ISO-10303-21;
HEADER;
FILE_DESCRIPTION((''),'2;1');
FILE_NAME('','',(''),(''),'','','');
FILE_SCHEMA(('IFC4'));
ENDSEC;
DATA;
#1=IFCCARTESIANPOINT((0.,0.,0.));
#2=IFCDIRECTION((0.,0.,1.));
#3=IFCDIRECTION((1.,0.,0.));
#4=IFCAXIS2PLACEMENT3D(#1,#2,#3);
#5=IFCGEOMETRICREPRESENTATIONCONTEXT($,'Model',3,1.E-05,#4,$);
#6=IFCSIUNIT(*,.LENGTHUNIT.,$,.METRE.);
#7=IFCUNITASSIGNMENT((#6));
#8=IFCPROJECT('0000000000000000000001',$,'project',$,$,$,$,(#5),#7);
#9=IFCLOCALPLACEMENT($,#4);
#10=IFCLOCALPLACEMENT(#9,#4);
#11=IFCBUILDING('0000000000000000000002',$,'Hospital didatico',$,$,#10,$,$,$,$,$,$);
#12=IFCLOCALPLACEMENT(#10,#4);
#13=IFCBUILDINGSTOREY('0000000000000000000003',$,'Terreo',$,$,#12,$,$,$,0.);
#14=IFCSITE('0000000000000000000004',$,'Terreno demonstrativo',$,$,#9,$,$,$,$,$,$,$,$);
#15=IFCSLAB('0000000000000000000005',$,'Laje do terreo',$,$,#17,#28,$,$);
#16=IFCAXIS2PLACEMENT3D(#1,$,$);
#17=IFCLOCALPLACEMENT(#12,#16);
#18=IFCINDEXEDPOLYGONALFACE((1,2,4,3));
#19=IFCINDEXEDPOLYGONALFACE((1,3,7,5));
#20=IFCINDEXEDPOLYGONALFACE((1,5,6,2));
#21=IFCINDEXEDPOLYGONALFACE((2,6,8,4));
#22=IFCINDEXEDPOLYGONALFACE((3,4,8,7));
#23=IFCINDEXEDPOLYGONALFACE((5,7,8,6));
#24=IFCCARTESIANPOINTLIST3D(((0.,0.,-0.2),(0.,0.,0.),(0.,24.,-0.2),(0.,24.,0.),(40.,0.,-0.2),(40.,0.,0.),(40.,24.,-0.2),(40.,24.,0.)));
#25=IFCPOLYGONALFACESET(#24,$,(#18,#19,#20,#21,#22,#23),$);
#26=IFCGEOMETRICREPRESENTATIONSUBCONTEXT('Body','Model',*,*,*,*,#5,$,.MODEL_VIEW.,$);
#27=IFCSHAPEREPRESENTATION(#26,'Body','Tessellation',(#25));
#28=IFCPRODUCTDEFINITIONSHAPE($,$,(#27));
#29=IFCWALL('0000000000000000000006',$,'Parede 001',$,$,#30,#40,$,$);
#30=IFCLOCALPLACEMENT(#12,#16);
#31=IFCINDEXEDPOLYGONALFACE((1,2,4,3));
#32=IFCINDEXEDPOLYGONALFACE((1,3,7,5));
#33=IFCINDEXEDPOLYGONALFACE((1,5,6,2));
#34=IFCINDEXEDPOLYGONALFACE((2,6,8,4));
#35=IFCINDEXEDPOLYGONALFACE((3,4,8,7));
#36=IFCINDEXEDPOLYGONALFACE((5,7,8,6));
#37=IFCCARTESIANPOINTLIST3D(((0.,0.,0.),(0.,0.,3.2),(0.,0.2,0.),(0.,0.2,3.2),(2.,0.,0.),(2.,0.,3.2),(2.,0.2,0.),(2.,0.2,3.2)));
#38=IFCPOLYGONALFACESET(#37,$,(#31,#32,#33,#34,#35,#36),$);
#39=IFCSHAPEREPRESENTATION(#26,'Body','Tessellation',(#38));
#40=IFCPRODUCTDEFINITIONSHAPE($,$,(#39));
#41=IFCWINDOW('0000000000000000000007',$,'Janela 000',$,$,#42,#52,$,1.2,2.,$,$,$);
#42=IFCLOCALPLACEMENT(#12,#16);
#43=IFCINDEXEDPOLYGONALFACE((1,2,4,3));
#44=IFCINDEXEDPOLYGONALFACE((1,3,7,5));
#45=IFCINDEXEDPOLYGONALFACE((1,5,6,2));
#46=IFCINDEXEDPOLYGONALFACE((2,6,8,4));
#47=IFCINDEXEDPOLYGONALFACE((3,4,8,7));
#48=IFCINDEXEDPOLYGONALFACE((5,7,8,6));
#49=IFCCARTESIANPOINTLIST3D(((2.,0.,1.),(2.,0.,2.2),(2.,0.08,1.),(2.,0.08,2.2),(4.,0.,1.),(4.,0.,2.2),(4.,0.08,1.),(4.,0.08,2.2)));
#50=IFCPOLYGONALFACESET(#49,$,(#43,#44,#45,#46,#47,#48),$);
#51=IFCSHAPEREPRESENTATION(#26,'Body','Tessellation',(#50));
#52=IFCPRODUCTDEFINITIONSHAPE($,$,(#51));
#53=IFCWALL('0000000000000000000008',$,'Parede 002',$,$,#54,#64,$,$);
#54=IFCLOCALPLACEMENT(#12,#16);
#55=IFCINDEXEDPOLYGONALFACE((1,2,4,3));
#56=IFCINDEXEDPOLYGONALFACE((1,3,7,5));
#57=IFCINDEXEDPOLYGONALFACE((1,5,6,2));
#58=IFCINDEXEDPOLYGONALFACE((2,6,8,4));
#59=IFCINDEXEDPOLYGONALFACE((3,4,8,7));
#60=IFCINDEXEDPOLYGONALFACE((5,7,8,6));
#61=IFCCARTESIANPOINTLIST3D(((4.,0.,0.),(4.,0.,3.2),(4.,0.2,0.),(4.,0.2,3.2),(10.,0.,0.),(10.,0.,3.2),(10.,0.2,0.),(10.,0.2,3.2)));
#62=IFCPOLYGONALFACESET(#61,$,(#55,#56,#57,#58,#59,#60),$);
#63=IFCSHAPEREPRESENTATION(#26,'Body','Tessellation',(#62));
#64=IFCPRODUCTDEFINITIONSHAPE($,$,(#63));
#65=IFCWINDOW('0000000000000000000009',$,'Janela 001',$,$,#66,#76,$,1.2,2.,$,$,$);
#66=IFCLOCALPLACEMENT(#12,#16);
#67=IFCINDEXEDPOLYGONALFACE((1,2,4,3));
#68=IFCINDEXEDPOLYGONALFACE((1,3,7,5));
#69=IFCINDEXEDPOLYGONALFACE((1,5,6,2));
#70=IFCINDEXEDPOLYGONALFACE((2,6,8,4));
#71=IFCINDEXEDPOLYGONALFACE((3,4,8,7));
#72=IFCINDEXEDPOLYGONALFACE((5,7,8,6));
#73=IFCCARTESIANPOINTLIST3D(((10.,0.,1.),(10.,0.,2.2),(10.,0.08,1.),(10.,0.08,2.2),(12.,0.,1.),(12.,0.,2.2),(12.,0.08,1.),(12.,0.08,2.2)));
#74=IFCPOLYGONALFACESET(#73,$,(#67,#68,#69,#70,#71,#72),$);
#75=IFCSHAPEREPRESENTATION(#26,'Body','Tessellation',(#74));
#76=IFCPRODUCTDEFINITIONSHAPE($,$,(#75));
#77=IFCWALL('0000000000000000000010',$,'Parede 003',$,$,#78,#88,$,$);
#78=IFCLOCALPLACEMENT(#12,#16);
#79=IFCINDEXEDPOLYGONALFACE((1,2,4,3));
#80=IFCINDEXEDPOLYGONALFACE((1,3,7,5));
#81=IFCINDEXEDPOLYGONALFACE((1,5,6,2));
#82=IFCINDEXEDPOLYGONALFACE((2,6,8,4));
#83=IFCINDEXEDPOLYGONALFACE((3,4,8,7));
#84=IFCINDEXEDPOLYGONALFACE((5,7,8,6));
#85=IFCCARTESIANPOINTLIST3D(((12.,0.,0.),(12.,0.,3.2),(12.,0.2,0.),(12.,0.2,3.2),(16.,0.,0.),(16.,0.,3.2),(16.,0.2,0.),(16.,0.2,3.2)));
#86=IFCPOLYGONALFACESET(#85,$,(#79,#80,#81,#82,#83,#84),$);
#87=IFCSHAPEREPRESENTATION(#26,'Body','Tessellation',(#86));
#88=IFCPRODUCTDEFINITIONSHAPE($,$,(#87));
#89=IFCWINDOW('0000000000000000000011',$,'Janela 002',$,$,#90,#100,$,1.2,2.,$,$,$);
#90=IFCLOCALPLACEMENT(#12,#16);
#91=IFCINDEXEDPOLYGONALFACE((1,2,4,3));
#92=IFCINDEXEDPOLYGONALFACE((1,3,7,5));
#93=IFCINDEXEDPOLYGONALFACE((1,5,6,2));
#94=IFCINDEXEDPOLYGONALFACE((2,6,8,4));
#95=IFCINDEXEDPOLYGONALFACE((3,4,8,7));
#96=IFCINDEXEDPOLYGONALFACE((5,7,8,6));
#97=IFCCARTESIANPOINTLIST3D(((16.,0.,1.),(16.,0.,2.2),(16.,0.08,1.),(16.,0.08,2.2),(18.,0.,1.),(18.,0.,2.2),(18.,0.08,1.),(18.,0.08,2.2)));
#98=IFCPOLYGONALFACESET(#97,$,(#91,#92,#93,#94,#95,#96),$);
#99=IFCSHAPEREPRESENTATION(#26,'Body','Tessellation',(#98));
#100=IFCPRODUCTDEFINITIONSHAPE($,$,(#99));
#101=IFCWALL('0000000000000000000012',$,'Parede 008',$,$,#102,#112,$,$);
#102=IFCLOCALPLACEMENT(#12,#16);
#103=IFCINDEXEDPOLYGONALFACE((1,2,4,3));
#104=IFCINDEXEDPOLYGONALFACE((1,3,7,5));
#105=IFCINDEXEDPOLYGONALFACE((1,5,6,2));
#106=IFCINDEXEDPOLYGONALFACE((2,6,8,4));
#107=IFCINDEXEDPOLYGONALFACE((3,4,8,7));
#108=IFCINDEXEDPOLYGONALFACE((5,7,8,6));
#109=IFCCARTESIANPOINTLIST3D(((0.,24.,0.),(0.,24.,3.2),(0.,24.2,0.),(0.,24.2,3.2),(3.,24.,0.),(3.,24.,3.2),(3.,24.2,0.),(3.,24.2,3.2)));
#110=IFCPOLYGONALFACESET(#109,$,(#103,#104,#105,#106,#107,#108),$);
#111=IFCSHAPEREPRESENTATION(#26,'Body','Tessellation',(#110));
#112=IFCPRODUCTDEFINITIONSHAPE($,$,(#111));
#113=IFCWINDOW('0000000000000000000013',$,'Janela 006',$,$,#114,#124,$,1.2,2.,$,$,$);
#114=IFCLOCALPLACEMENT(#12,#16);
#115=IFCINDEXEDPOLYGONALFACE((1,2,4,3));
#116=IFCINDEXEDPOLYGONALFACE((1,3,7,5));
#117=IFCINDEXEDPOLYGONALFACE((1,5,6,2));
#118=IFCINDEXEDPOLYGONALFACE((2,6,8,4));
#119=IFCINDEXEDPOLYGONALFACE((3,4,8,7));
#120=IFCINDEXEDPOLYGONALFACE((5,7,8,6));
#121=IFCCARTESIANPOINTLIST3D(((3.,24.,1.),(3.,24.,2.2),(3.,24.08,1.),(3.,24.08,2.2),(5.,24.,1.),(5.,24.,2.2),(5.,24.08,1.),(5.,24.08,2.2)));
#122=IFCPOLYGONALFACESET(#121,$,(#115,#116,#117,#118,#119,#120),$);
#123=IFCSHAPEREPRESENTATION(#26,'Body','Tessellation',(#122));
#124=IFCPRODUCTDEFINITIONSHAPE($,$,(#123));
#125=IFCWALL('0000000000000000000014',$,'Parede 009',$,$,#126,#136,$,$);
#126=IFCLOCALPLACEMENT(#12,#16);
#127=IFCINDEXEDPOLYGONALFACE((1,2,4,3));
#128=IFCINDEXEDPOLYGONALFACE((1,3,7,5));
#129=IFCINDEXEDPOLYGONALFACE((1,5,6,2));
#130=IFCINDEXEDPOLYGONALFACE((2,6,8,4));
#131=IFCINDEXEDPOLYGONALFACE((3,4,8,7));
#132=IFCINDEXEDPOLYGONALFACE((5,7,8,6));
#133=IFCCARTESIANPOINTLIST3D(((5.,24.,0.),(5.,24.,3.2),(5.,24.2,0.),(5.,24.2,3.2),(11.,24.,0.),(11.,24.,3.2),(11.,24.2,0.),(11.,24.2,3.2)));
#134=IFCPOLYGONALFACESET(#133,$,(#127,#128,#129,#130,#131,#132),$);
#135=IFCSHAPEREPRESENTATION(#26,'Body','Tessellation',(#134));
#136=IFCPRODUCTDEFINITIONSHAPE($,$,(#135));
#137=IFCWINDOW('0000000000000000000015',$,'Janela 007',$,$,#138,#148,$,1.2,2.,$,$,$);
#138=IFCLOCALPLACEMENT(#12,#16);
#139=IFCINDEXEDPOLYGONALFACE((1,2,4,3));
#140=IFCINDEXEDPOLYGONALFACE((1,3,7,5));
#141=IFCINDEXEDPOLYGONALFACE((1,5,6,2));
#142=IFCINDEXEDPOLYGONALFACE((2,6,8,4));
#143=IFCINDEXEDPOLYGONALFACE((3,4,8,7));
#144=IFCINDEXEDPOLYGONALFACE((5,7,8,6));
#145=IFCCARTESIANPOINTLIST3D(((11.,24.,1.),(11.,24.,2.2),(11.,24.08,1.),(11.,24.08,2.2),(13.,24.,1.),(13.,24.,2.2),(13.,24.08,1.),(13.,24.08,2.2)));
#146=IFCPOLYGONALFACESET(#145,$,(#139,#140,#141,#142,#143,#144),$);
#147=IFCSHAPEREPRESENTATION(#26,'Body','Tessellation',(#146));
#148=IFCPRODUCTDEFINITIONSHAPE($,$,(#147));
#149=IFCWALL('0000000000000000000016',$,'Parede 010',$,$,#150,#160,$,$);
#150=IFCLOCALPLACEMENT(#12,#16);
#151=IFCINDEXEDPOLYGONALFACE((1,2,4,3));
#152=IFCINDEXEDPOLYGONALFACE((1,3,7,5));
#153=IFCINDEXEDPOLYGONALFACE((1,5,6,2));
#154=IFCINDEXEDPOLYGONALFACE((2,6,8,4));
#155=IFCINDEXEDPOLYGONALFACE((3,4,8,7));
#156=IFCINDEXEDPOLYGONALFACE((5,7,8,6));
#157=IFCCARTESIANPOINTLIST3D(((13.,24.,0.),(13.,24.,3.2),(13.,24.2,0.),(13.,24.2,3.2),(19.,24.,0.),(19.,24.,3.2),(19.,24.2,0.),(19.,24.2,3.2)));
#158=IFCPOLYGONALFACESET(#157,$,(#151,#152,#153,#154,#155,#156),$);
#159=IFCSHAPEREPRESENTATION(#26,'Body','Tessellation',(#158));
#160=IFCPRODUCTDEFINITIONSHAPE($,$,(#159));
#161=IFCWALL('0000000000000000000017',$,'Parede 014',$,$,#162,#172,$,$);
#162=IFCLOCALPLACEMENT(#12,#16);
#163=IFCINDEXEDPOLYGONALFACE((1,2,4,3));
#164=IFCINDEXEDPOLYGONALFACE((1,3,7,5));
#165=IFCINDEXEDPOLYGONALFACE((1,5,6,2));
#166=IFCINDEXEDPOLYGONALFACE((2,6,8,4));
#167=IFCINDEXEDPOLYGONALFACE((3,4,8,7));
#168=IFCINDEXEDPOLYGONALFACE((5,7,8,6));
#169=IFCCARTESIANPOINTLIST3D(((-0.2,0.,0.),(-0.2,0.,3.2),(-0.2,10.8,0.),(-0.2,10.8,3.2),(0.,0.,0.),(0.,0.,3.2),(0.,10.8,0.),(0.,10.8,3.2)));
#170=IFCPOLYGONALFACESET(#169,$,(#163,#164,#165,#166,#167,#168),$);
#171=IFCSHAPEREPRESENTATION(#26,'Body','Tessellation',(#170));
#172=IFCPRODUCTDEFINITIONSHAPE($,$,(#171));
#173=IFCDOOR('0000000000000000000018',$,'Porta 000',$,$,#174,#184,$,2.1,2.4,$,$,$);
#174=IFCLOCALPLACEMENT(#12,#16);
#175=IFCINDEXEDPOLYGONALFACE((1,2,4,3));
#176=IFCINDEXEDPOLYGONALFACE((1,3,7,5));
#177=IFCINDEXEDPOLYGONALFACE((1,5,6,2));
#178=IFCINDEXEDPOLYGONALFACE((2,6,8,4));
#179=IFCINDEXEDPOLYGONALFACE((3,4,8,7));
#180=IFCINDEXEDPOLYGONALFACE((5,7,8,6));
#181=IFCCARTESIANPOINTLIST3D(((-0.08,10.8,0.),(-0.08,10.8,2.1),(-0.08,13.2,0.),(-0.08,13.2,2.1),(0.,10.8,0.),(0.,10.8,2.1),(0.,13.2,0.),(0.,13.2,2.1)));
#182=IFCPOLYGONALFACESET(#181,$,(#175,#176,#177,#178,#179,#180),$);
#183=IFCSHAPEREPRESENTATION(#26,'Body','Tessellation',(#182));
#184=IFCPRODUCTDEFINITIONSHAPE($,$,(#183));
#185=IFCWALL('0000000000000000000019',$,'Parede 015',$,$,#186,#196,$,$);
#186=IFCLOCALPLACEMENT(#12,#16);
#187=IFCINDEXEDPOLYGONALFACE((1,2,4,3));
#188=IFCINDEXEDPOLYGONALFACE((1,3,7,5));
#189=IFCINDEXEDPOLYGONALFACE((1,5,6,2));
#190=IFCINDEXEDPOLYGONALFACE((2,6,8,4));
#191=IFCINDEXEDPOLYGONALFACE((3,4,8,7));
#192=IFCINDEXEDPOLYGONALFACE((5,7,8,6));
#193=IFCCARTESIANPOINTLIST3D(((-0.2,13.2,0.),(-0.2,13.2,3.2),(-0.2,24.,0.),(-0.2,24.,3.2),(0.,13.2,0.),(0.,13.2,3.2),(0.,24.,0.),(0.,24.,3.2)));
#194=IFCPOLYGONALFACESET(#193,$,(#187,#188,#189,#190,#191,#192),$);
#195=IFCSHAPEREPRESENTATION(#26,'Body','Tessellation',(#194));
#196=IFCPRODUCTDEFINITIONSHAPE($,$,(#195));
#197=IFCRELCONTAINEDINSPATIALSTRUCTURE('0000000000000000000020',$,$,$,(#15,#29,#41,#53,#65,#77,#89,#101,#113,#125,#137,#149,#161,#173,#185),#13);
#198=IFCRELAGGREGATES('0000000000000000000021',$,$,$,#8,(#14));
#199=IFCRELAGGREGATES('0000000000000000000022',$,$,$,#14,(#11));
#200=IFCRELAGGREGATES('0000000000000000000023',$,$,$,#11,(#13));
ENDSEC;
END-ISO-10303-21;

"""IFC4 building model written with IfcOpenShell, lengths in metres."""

from ifc_helpers import new_model, si_unit, frame, origin_with_axes, place, context, subcontext, project, spatial, indexed_curve, outline, extrude, element, save


model = new_model("IFC4")

# Units and contexts
model_context = context("Model", 3, precision=1e-05, world=origin_with_axes())
body_context = subcontext(model_context, "Body", "Model", "MODEL_VIEW")
ifc_project = project(units=[si_unit("LENGTHUNIT", "METRE")], contexts=[model_context])

# Site, building, storey
site_placement = place(None, origin_with_axes())
site = spatial("IfcSite", under=ifc_project, at=site_placement, Name="Terreno demonstrativo")
building_placement = place(site_placement, origin_with_axes())
building = spatial("IfcBuilding", under=site, at=building_placement, Name="Hospital didatico")
storey_placement = place(building_placement, origin_with_axes())
storey = spatial("IfcBuildingStorey", under=building, at=storey_placement, Name="Terreo", Elevation=0.0)

# Slab
slab_placement = place(storey_placement, frame((0.0, 0.0, -0.2), z_axis=(0.0, 0.0, 1.0), x_axis=(1.0, 0.0, 0.0)))
element("IfcSlab", 1, at=slab_placement, inside=storey, Name="Laje do terreo", context=body_context, shape_type="SweptSolid", body=[
    extrude(outline(indexed_curve([(0.0, 0.0), (0.0, 24.0), (40.0, 24.0), (40.0, 0.0), (0.0, 0.0)], self_intersect=False)), origin_with_axes(), (0.0, 0.0, 1.0), 0.2),
])

# Wall
wall_1_placement = place(storey_placement, origin_with_axes())
element("IfcWall", 2, at=wall_1_placement, inside=storey, Name="Parede 001", context=body_context, shape_type="SweptSolid", body=[
    extrude(outline(indexed_curve([(0.0, 0.0), (0.0, 0.2), (2.0, 0.2), (2.0, 0.0), (0.0, 0.0)], self_intersect=False)), origin_with_axes(), (0.0, 0.0, 1.0), 3.2),
])

# Window
window_1_placement = place(storey_placement, frame((2.0, 0.0, 1.0), z_axis=(0.0, 0.0, 1.0), x_axis=(1.0, 0.0, 0.0)))
element("IfcWindow", 3, at=window_1_placement, inside=storey, Name="Janela 000", OverallHeight=1.2, OverallWidth=2.0, context=body_context, shape_type="SweptSolid", body=[
    extrude(outline(indexed_curve([(0.0, 0.0), (0.0, 0.08), (2.0, 0.08), (2.0, 0.0), (0.0, 0.0)], self_intersect=False)), origin_with_axes(), (0.0, 0.0, 1.0), 1.2),
])

# Wall
wall_2_placement = place(storey_placement, frame((4.0, 0.0, 0.0), z_axis=(0.0, 0.0, 1.0), x_axis=(1.0, 0.0, 0.0)))
element("IfcWall", 4, at=wall_2_placement, inside=storey, Name="Parede 002", context=body_context, shape_type="SweptSolid", body=[
    extrude(outline(indexed_curve([(0.0, 0.0), (0.0, 0.2), (6.0, 0.2), (6.0, 0.0), (0.0, 0.0)], self_intersect=False)), origin_with_axes(), (0.0, 0.0, 1.0), 3.2),
])

# Window
window_2_placement = place(storey_placement, frame((10.0, 0.0, 1.0), z_axis=(0.0, 0.0, 1.0), x_axis=(1.0, 0.0, 0.0)))
element("IfcWindow", 5, at=window_2_placement, inside=storey, Name="Janela 001", OverallHeight=1.2, OverallWidth=2.0, context=body_context, shape_type="SweptSolid", body=[
    extrude(outline(indexed_curve([(0.0, 0.0), (0.0, 0.08), (2.0, 0.08), (2.0, 0.0), (0.0, 0.0)], self_intersect=False)), origin_with_axes(), (0.0, 0.0, 1.0), 1.2),
])

# Wall
wall_3_placement = place(storey_placement, frame((12.0, 0.0, 0.0), z_axis=(0.0, 0.0, 1.0), x_axis=(1.0, 0.0, 0.0)))
element("IfcWall", 6, at=wall_3_placement, inside=storey, Name="Parede 003", context=body_context, shape_type="SweptSolid", body=[
    extrude(outline(indexed_curve([(0.0, 0.0), (0.0, 0.2), (4.0, 0.2), (4.0, 0.0), (0.0, 0.0)], self_intersect=False)), origin_with_axes(), (0.0, 0.0, 1.0), 3.2),
])

# Window
window_3_placement = place(storey_placement, frame((16.0, 0.0, 1.0), z_axis=(0.0, 0.0, 1.0), x_axis=(1.0, 0.0, 0.0)))
element("IfcWindow", 7, at=window_3_placement, inside=storey, Name="Janela 002", OverallHeight=1.2, OverallWidth=2.0, context=body_context, shape_type="SweptSolid", body=[
    extrude(outline(indexed_curve([(0.0, 0.0), (0.0, 0.08), (2.0, 0.08), (2.0, 0.0), (0.0, 0.0)], self_intersect=False)), origin_with_axes(), (0.0, 0.0, 1.0), 1.2),
])

# Wall
wall_4_placement = place(storey_placement, frame((0.0, 24.0, 0.0), z_axis=(0.0, 0.0, 1.0), x_axis=(1.0, 0.0, 0.0)))
element("IfcWall", 8, at=wall_4_placement, inside=storey, Name="Parede 008", context=body_context, shape_type="SweptSolid", body=[
    extrude(outline(indexed_curve([(0.0, 0.0), (0.0, 0.2), (3.0, 0.2), (3.0, 0.0), (0.0, 0.0)], self_intersect=False)), origin_with_axes(), (0.0, 0.0, 1.0), 3.2),
])

# Window
window_4_placement = place(storey_placement, frame((3.0, 24.0, 1.0), z_axis=(0.0, 0.0, 1.0), x_axis=(1.0, 0.0, 0.0)))
element("IfcWindow", 9, at=window_4_placement, inside=storey, Name="Janela 006", OverallHeight=1.2, OverallWidth=2.0, context=body_context, shape_type="SweptSolid", body=[
    extrude(outline(indexed_curve([(0.0, 0.0), (0.0, 0.08), (2.0, 0.08), (2.0, 0.0), (0.0, 0.0)], self_intersect=False)), origin_with_axes(), (0.0, 0.0, 1.0), 1.2),
])

# Wall
wall_5_placement = place(storey_placement, frame((5.0, 24.0, 0.0), z_axis=(0.0, 0.0, 1.0), x_axis=(1.0, 0.0, 0.0)))
element("IfcWall", 10, at=wall_5_placement, inside=storey, Name="Parede 009", context=body_context, shape_type="SweptSolid", body=[
    extrude(outline(indexed_curve([(0.0, 0.0), (0.0, 0.2), (6.0, 0.2), (6.0, 0.0), (0.0, 0.0)], self_intersect=False)), origin_with_axes(), (0.0, 0.0, 1.0), 3.2),
])

# Window
window_5_placement = place(storey_placement, frame((11.0, 24.0, 1.0), z_axis=(0.0, 0.0, 1.0), x_axis=(1.0, 0.0, 0.0)))
element("IfcWindow", 11, at=window_5_placement, inside=storey, Name="Janela 007", OverallHeight=1.2, OverallWidth=2.0, context=body_context, shape_type="SweptSolid", body=[
    extrude(outline(indexed_curve([(0.0, 0.0), (0.0, 0.08), (2.0, 0.08), (2.0, 0.0), (0.0, 0.0)], self_intersect=False)), origin_with_axes(), (0.0, 0.0, 1.0), 1.2),
])

# Walls
wall_6_placement = place(storey_placement, frame((13.0, 24.0, 0.0), z_axis=(0.0, 0.0, 1.0), x_axis=(1.0, 0.0, 0.0)))
element("IfcWall", 12, at=wall_6_placement, inside=storey, Name="Parede 010", context=body_context, shape_type="SweptSolid", body=[
    extrude(outline(indexed_curve([(0.0, 0.0), (0.0, 0.2), (6.0, 0.2), (6.0, 0.0), (0.0, 0.0)], self_intersect=False)), origin_with_axes(), (0.0, 0.0, 1.0), 3.2),
])
wall_7_placement = place(storey_placement, frame((0.0, 0.0, 0.0), z_axis=(0.0, 0.0, 1.0), x_axis=(0.0, 1.0, 0.0)))
element("IfcWall", 13, at=wall_7_placement, inside=storey, Name="Parede 014", context=body_context, shape_type="SweptSolid", body=[
    extrude(outline(indexed_curve([(0.0, 0.0), (0.0, 0.2), (10.8, 0.2), (10.8, 0.0), (0.0, 0.0)], self_intersect=False)), origin_with_axes(), (0.0, 0.0, 1.0), 3.2),
])

# Door
door_1_placement = place(storey_placement, frame((0.0, 10.8, 0.0), z_axis=(0.0, 0.0, 1.0), x_axis=(0.0, 1.0, 0.0)))
element("IfcDoor", 14, at=door_1_placement, inside=storey, Name="Porta 000", OverallHeight=2.1, OverallWidth=2.4, context=body_context, shape_type="SweptSolid", body=[
    extrude(outline(indexed_curve([(0.0, 0.0), (0.0, 0.08), (2.4, 0.08), (2.4, 0.0), (0.0, 0.0)], self_intersect=False)), origin_with_axes(), (0.0, 0.0, 1.0), 2.1),
])

# Wall
wall_8_placement = place(storey_placement, frame((0.0, 13.2, 0.0), z_axis=(0.0, 0.0, 1.0), x_axis=(0.0, 1.0, 0.0)))
element("IfcWall", 15, at=wall_8_placement, inside=storey, Name="Parede 015", context=body_context, shape_type="SweptSolid", body=[
    extrude(outline(indexed_curve([(0.0, 0.0), (0.0, 0.2), (10.8, 0.2), (10.8, 0.0), (0.0, 0.0)], self_intersect=False)), origin_with_axes(), (0.0, 0.0, 1.0), 3.2),
])

save(model, "model.ifc")
